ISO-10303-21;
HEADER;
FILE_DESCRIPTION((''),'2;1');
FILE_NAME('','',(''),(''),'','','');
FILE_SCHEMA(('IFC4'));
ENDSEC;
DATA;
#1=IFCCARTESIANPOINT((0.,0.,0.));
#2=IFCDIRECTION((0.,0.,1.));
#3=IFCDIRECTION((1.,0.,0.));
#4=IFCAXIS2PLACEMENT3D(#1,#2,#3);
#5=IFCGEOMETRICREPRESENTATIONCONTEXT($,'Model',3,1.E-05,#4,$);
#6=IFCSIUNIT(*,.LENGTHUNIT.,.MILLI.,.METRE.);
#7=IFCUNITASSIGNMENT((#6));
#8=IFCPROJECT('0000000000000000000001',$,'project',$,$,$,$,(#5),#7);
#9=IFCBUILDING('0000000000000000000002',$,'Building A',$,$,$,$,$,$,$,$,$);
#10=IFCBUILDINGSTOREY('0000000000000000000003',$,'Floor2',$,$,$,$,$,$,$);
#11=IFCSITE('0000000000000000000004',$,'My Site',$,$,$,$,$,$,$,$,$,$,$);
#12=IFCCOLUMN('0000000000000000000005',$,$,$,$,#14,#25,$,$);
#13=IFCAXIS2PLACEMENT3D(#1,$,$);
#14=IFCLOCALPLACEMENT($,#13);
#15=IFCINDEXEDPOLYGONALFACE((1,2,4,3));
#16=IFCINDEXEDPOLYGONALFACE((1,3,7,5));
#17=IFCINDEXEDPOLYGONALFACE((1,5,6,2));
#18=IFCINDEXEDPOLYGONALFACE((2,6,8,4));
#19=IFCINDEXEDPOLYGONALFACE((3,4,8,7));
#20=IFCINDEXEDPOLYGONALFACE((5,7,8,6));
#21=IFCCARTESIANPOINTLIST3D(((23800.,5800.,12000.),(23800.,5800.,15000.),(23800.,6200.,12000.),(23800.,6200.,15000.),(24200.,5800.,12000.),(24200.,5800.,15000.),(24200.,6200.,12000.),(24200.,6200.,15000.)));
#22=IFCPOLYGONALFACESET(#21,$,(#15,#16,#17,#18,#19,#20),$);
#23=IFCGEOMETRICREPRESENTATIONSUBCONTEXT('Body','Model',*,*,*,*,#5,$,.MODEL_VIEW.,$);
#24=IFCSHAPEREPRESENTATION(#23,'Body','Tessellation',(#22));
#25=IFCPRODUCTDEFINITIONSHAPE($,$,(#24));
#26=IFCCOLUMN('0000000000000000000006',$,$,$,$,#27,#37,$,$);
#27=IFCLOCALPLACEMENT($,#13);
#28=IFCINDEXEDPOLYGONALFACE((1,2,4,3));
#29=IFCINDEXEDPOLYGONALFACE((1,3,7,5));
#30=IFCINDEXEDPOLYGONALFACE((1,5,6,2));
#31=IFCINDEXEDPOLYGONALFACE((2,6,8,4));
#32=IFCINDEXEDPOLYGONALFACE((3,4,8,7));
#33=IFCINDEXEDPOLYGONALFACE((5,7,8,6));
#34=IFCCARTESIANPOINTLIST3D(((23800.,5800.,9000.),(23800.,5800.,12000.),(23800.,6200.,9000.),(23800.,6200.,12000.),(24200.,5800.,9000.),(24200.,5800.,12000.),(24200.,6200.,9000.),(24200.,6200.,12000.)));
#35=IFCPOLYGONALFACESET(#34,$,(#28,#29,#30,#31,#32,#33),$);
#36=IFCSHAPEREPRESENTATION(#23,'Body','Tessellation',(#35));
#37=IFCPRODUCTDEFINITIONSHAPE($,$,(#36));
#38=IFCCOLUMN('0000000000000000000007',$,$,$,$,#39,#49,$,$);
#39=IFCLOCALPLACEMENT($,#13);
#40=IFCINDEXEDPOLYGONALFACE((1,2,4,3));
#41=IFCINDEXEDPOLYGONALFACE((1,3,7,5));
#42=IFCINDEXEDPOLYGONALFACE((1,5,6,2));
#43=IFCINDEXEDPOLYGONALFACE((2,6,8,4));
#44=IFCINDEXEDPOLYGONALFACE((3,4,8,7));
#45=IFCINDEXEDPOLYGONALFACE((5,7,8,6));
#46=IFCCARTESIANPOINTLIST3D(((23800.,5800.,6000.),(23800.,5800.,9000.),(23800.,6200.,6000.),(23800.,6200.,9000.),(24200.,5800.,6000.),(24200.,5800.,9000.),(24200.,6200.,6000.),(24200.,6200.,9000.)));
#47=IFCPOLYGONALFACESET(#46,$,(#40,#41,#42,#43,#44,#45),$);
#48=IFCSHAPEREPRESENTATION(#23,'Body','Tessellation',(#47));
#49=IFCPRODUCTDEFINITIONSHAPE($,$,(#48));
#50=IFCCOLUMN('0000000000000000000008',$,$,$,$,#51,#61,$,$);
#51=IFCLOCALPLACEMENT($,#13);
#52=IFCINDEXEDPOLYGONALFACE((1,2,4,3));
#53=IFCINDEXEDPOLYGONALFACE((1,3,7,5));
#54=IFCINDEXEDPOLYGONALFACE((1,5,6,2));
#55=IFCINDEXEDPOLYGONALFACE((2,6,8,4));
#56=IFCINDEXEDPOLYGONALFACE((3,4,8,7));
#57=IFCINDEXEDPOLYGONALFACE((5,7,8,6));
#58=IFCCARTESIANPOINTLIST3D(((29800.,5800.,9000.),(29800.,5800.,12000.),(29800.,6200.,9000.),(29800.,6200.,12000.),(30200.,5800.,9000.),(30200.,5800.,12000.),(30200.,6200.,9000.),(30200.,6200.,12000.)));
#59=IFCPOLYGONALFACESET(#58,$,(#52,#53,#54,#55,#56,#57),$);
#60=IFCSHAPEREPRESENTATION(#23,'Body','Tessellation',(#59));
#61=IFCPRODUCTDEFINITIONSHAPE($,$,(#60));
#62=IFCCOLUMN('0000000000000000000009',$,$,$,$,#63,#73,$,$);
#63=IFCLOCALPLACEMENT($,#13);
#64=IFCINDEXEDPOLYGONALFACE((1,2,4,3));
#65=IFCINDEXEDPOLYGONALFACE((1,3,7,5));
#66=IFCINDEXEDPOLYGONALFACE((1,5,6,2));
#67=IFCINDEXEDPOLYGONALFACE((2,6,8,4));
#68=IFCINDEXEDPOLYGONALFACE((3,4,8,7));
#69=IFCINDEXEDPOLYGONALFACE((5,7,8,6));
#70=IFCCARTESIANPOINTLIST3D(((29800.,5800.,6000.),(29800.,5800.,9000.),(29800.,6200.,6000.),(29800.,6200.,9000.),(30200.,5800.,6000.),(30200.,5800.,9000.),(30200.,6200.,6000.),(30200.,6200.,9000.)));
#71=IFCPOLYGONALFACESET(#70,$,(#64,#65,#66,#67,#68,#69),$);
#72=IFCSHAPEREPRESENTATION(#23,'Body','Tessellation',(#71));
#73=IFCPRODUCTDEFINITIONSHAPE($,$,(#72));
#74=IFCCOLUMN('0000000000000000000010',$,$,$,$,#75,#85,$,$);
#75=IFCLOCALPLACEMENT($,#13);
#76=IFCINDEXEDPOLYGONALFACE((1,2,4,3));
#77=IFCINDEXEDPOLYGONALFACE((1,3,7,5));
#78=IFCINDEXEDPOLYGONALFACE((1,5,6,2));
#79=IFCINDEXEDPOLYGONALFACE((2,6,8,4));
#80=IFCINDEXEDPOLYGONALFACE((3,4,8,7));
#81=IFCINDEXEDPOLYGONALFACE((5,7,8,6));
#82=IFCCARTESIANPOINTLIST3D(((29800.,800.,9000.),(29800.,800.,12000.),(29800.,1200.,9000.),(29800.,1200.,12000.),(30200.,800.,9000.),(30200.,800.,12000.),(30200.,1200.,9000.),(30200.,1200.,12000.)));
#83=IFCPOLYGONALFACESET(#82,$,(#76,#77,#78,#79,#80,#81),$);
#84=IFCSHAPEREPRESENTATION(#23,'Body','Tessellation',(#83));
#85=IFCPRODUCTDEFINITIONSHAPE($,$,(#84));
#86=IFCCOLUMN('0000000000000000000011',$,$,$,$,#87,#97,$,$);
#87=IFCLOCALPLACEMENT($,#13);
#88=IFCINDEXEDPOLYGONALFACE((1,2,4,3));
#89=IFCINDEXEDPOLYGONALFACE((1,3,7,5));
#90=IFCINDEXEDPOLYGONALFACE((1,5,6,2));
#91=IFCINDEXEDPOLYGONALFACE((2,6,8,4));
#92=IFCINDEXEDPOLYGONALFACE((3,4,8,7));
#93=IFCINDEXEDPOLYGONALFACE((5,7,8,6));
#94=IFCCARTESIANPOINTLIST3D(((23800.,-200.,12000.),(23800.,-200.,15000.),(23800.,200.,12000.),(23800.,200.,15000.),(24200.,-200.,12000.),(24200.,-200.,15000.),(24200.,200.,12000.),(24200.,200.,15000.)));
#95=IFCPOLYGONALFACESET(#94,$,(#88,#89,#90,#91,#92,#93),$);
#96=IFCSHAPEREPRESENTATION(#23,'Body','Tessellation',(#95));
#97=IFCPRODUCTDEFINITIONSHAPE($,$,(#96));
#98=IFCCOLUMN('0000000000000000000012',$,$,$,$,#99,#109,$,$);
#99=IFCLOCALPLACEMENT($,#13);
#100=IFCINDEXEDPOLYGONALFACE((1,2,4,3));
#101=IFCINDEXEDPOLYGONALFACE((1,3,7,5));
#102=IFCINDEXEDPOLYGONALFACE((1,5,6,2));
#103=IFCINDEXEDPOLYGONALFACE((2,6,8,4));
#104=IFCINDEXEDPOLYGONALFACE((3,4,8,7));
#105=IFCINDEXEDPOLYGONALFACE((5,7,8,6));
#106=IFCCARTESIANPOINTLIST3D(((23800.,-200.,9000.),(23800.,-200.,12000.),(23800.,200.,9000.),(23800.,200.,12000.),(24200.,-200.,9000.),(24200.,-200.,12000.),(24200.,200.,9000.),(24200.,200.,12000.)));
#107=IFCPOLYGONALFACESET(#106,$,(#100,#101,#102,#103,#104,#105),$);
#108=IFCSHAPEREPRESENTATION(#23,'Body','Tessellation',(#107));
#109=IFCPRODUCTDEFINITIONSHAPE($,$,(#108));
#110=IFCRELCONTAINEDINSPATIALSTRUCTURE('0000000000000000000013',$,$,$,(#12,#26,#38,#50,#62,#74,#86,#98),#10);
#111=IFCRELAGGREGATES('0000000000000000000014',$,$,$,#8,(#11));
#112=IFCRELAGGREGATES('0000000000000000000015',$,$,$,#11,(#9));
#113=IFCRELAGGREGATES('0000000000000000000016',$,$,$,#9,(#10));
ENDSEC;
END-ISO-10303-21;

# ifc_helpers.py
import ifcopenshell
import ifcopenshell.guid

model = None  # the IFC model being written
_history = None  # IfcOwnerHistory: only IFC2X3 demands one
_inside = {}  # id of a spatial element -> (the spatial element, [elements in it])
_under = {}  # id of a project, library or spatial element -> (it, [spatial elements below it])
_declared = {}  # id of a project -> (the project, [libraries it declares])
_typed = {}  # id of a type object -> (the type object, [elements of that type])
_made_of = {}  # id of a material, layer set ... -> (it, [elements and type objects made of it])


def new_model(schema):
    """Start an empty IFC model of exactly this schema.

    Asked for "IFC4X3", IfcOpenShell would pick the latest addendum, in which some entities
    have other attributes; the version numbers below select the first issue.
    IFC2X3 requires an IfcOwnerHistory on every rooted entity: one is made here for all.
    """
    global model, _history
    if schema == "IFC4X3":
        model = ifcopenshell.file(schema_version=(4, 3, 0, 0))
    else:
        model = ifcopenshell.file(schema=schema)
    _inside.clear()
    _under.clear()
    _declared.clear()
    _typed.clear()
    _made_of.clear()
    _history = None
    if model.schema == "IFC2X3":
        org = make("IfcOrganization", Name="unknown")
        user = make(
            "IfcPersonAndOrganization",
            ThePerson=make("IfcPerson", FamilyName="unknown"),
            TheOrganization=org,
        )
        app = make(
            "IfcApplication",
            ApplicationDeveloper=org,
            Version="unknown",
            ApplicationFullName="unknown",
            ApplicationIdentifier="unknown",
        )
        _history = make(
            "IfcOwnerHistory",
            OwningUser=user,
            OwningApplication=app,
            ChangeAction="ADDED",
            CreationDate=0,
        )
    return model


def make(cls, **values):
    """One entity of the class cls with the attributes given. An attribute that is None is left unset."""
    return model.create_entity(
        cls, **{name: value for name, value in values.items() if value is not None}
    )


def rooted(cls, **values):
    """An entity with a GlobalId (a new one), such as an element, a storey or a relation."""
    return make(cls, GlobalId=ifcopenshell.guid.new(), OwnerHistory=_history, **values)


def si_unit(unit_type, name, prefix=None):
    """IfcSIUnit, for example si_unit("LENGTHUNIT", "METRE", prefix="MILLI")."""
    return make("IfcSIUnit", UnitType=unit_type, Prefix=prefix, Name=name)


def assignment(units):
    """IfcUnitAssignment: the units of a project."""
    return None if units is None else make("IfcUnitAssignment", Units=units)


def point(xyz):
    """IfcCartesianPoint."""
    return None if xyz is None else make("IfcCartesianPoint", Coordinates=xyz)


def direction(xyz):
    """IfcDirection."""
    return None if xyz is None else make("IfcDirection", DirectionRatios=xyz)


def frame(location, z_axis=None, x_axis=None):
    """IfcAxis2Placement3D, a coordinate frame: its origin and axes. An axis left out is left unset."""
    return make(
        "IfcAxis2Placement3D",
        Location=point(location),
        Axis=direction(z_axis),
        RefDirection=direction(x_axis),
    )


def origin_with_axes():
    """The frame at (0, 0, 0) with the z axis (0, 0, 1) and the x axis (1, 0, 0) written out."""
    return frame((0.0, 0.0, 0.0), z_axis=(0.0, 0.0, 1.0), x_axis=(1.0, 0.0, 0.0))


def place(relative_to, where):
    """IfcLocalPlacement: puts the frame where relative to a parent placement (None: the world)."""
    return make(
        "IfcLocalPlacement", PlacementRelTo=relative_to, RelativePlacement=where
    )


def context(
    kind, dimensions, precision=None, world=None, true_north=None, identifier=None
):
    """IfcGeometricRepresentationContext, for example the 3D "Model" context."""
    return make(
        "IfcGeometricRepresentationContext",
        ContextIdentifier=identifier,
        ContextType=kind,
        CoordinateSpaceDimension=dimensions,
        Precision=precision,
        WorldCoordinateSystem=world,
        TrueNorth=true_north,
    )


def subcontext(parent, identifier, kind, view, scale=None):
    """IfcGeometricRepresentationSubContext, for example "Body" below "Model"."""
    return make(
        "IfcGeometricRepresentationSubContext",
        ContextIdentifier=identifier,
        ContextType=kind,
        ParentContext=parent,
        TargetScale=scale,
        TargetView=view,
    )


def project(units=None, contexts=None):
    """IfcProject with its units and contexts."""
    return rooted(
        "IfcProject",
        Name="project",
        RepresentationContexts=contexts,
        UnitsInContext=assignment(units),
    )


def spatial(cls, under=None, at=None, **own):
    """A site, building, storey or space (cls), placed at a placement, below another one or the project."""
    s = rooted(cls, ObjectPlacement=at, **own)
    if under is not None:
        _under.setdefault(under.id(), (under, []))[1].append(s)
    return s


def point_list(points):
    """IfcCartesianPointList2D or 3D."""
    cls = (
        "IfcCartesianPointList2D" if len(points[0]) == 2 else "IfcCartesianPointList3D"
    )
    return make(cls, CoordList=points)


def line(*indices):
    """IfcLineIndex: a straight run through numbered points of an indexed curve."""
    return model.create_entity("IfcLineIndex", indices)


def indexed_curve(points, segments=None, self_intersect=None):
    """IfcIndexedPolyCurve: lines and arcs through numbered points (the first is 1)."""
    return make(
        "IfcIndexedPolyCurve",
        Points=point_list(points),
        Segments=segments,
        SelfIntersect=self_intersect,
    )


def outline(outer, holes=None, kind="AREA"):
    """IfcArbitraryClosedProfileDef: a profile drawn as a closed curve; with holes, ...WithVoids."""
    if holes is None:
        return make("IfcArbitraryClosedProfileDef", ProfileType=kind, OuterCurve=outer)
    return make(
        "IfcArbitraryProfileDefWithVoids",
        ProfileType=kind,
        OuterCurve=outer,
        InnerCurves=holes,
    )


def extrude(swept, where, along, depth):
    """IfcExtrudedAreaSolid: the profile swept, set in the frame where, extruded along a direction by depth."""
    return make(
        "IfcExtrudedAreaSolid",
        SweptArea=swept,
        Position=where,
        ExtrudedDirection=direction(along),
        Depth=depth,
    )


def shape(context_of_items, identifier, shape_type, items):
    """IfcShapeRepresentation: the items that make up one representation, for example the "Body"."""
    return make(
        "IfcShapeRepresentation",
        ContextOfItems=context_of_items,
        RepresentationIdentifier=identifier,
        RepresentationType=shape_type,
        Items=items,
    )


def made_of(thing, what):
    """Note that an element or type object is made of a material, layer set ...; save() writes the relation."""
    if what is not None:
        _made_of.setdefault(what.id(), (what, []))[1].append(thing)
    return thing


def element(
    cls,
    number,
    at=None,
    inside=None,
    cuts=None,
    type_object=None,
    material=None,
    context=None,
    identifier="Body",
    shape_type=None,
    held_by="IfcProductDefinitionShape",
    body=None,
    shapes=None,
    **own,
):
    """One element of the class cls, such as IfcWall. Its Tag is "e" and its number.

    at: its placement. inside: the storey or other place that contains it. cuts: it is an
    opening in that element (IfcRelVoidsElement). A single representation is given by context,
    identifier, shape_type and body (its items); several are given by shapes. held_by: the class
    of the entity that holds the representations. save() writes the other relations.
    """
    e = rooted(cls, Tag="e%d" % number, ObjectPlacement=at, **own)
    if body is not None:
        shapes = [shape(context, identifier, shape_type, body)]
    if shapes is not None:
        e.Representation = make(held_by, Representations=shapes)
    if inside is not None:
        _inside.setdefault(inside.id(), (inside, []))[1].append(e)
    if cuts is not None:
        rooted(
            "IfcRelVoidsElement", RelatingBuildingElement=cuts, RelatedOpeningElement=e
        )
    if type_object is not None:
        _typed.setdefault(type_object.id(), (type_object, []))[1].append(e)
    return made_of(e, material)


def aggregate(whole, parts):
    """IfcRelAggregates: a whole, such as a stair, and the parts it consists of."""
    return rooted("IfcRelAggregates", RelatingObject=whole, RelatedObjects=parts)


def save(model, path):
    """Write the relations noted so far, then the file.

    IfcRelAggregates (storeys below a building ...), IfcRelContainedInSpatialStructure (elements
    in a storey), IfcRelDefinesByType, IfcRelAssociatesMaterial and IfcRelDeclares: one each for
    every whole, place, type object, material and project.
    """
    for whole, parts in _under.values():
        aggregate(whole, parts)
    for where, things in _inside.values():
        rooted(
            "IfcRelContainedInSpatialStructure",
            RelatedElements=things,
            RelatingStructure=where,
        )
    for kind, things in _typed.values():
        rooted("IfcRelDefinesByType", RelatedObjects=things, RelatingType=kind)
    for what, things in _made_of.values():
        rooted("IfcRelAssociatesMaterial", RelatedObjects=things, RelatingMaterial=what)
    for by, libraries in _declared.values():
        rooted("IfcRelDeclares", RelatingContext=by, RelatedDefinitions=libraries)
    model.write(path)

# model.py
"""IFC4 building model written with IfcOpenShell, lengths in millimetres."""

from ifc_helpers import new_model, si_unit, frame, origin_with_axes, place, context, subcontext, project, spatial, line, indexed_curve, outline, extrude, element, save


model = new_model("IFC4")

# Units and contexts
model_context = context("Model", 3, precision=1e-05, world=origin_with_axes())
body_context = subcontext(model_context, "Body", "Model", "MODEL_VIEW")
ifc_project = project(units=[si_unit("LENGTHUNIT", "METRE", prefix="MILLI")], contexts=[model_context])

# Site, building, storey
site = spatial("IfcSite", under=ifc_project, Name="My Site")
building = spatial("IfcBuilding", under=site, Name="Building A")
storey = spatial("IfcBuildingStorey", under=building, Name="Floor2")

# Columns
for number, where, z_axis, x_axis in (
    (1, (24000.0, 6000.0, 12000.0), (0.0, 0.0, 1.0), (1.0, 0.0, 0.0)),
    (2, (24000.0, 6000.0, 9000.0), (0.0, 0.0, 1.0), (1.0, 0.0, 0.0)),
    (3, (24000.0, 6000.0, 6000.0), (0.0, 0.0, 1.0), (1.0, 0.0, 0.0)),
    (4, (30000.0, 6000.0, 9000.0), (0.0, 0.0, 1.0), (1.0, 0.0, 0.0)),
    (5, (30000.0, 6000.0, 6000.0), (0.0, 0.0, 1.0), (1.0, 0.0, 0.0)),
    (6, (30000.0, 1000.0, 9000.0), (0.0, 0.0, 1.0), (1.0, 0.0, 0.0)),
    (7, (24000.0, 0.0, 12000.0), (0.0, 0.0, 1.0), (1.0, 0.0, 0.0)),
    (8, (24000.0, 0.0, 9000.0), (0.0, 0.0, 1.0), (1.0, 0.0, 0.0)),
):
    element("IfcColumn", number, at=place(None, frame(where, z_axis=z_axis, x_axis=x_axis)), inside=storey, context=body_context, shape_type="SweptSolid", body=[
        extrude(outline(indexed_curve([(-200.0, -200.0), (200.0, -200.0), (200.0, 200.0), (-200.0, 200.0)], segments=[line(1, 2, 3, 4, 1)])), origin_with_axes(), (0.0, 0.0, 1.0), 3000.0),
    ])

save(model, "model.ifc")
